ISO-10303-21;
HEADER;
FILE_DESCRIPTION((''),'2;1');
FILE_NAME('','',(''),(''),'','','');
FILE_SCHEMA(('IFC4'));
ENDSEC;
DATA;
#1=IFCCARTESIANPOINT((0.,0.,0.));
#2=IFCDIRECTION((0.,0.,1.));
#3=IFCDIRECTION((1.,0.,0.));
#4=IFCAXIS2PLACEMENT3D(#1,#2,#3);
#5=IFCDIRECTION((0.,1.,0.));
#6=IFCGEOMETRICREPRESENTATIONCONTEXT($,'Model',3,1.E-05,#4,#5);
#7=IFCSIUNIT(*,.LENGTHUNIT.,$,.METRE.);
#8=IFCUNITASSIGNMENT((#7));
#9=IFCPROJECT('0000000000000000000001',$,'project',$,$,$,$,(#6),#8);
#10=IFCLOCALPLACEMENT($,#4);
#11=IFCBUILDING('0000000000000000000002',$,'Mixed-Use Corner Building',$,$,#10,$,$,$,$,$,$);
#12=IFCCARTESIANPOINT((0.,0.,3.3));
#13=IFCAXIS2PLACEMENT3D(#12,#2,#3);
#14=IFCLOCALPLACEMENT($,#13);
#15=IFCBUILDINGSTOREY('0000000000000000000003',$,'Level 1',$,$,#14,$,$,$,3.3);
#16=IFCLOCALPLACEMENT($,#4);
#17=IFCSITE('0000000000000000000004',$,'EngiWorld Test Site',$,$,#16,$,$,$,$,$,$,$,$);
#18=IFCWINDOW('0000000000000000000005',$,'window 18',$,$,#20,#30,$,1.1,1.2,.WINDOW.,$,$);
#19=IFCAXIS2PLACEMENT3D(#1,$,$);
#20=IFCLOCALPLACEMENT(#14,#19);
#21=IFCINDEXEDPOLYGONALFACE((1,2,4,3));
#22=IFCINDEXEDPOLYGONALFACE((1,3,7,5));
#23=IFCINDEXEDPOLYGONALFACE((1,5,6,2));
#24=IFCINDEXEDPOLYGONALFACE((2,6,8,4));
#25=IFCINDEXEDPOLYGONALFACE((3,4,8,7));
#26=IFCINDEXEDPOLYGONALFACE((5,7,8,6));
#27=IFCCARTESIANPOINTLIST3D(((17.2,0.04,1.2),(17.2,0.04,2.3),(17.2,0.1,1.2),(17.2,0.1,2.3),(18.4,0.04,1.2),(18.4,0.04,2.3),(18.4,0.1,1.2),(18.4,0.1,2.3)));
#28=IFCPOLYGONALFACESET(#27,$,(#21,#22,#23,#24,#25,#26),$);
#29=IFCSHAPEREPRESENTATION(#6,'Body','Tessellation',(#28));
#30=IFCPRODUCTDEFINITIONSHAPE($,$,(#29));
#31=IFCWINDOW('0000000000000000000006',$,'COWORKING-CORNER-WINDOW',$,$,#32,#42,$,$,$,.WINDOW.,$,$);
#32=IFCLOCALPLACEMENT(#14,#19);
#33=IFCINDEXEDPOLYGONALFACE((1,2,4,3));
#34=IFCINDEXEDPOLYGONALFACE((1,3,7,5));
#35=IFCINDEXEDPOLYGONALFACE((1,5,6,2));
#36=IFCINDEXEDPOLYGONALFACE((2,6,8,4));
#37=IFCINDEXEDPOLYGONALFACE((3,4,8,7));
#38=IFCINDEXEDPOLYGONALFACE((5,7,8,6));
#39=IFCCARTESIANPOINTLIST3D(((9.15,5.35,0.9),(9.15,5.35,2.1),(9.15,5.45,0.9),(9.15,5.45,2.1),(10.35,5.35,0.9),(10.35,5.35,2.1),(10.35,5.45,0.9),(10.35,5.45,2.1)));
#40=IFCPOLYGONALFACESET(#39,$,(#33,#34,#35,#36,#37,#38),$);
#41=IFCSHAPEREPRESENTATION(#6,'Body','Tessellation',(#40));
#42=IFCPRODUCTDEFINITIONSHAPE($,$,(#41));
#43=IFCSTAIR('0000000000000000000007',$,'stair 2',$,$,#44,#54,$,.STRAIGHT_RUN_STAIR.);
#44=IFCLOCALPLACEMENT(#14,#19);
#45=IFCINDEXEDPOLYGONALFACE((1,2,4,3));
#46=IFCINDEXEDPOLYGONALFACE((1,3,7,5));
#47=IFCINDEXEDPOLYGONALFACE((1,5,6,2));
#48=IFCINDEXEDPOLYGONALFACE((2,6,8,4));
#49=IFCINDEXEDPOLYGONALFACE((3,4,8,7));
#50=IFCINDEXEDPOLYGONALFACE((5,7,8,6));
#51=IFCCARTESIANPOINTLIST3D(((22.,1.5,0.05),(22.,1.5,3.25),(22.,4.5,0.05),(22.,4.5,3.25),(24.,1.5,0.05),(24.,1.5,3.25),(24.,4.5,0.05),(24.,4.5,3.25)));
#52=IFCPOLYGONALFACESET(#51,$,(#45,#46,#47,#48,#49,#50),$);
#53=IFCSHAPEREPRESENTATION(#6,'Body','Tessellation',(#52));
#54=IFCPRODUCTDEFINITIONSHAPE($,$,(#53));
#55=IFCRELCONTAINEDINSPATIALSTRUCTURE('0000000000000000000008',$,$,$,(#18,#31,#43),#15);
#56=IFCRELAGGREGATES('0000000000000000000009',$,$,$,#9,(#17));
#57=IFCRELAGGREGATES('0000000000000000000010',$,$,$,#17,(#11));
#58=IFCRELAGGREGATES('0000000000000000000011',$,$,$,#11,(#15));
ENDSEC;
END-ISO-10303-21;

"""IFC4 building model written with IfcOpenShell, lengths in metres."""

from ifc_helpers import new_model, si_unit, direction, frame, origin, origin_with_axes, origin_2d, origin_2d_with_axis, place, context, project, spatial, rectangle, extrude, element, save


model = new_model("IFC4")

# Units and contexts
model_context = context("Model", 3, precision=1e-05, world=origin_with_axes(), true_north=direction((0.0, 1.0, 0.0)))
ifc_project = project(units=[si_unit("LENGTHUNIT", "METRE")], contexts=[model_context])

# Site, building, storey
site_placement = place(None, origin_with_axes())
site = spatial("IfcSite", under=ifc_project, at=site_placement, Name="EngiWorld Test Site")
building_placement = place(None, origin_with_axes())
building = spatial("IfcBuilding", under=site, at=building_placement, Name="Mixed-Use Corner Building")
storey_placement = place(None, frame((0.0, 0.0, 3.3), z_axis=(0.0, 0.0, 1.0), x_axis=(1.0, 0.0, 0.0)))
storey = spatial("IfcBuildingStorey", under=building, at=storey_placement, Name="Level 1", Elevation=3.3)

# Windows
for number, where, z_axis, x_axis, name in (
    (1, (17.8, 0.07, 4.5), (0.0, 0.0, 1.0), (1.0, 0.0, 0.0), "window 18"),
):
    element("IfcWindow", number, at=place(None, frame(where, z_axis=z_axis, x_axis=x_axis)), inside=storey, Name=name, OverallHeight=1.1, OverallWidth=1.2, PredefinedType="WINDOW", context=model_context, shape_type="SweptSolid", body=[
        extrude(rectangle(XDim=1.2, YDim=0.06, at=origin_2d_with_axis()), origin_with_axes(), (0.0, 0.0, 1.0), 1.1),
    ])
window_placement = place(None, frame((9.75, 5.4, 4.2)))
element("IfcWindow", 2, at=window_placement, inside=storey, Name="COWORKING-CORNER-WINDOW", PredefinedType="WINDOW", context=model_context, shape_type="SweptSolid", body=[
    extrude(rectangle(XDim=1.2, YDim=0.1, at=origin_2d()), origin(), (0.0, 0.0, 1.0), 1.2),
])

# Stair
stair_placement = place(None, frame((23.0, 3.0, 3.35), z_axis=(0.0, 0.0, 1.0), x_axis=(1.0, 0.0, 0.0)))
element("IfcStair", 3, at=stair_placement, inside=storey, Name="stair 2", PredefinedType="STRAIGHT_RUN_STAIR", context=model_context, shape_type="SweptSolid", body=[
    extrude(rectangle(XDim=2.0, YDim=3.0, at=origin_2d_with_axis()), origin_with_axes(), (0.0, 0.0, 1.0), 3.2),
])

save(model, "model.ifc")
